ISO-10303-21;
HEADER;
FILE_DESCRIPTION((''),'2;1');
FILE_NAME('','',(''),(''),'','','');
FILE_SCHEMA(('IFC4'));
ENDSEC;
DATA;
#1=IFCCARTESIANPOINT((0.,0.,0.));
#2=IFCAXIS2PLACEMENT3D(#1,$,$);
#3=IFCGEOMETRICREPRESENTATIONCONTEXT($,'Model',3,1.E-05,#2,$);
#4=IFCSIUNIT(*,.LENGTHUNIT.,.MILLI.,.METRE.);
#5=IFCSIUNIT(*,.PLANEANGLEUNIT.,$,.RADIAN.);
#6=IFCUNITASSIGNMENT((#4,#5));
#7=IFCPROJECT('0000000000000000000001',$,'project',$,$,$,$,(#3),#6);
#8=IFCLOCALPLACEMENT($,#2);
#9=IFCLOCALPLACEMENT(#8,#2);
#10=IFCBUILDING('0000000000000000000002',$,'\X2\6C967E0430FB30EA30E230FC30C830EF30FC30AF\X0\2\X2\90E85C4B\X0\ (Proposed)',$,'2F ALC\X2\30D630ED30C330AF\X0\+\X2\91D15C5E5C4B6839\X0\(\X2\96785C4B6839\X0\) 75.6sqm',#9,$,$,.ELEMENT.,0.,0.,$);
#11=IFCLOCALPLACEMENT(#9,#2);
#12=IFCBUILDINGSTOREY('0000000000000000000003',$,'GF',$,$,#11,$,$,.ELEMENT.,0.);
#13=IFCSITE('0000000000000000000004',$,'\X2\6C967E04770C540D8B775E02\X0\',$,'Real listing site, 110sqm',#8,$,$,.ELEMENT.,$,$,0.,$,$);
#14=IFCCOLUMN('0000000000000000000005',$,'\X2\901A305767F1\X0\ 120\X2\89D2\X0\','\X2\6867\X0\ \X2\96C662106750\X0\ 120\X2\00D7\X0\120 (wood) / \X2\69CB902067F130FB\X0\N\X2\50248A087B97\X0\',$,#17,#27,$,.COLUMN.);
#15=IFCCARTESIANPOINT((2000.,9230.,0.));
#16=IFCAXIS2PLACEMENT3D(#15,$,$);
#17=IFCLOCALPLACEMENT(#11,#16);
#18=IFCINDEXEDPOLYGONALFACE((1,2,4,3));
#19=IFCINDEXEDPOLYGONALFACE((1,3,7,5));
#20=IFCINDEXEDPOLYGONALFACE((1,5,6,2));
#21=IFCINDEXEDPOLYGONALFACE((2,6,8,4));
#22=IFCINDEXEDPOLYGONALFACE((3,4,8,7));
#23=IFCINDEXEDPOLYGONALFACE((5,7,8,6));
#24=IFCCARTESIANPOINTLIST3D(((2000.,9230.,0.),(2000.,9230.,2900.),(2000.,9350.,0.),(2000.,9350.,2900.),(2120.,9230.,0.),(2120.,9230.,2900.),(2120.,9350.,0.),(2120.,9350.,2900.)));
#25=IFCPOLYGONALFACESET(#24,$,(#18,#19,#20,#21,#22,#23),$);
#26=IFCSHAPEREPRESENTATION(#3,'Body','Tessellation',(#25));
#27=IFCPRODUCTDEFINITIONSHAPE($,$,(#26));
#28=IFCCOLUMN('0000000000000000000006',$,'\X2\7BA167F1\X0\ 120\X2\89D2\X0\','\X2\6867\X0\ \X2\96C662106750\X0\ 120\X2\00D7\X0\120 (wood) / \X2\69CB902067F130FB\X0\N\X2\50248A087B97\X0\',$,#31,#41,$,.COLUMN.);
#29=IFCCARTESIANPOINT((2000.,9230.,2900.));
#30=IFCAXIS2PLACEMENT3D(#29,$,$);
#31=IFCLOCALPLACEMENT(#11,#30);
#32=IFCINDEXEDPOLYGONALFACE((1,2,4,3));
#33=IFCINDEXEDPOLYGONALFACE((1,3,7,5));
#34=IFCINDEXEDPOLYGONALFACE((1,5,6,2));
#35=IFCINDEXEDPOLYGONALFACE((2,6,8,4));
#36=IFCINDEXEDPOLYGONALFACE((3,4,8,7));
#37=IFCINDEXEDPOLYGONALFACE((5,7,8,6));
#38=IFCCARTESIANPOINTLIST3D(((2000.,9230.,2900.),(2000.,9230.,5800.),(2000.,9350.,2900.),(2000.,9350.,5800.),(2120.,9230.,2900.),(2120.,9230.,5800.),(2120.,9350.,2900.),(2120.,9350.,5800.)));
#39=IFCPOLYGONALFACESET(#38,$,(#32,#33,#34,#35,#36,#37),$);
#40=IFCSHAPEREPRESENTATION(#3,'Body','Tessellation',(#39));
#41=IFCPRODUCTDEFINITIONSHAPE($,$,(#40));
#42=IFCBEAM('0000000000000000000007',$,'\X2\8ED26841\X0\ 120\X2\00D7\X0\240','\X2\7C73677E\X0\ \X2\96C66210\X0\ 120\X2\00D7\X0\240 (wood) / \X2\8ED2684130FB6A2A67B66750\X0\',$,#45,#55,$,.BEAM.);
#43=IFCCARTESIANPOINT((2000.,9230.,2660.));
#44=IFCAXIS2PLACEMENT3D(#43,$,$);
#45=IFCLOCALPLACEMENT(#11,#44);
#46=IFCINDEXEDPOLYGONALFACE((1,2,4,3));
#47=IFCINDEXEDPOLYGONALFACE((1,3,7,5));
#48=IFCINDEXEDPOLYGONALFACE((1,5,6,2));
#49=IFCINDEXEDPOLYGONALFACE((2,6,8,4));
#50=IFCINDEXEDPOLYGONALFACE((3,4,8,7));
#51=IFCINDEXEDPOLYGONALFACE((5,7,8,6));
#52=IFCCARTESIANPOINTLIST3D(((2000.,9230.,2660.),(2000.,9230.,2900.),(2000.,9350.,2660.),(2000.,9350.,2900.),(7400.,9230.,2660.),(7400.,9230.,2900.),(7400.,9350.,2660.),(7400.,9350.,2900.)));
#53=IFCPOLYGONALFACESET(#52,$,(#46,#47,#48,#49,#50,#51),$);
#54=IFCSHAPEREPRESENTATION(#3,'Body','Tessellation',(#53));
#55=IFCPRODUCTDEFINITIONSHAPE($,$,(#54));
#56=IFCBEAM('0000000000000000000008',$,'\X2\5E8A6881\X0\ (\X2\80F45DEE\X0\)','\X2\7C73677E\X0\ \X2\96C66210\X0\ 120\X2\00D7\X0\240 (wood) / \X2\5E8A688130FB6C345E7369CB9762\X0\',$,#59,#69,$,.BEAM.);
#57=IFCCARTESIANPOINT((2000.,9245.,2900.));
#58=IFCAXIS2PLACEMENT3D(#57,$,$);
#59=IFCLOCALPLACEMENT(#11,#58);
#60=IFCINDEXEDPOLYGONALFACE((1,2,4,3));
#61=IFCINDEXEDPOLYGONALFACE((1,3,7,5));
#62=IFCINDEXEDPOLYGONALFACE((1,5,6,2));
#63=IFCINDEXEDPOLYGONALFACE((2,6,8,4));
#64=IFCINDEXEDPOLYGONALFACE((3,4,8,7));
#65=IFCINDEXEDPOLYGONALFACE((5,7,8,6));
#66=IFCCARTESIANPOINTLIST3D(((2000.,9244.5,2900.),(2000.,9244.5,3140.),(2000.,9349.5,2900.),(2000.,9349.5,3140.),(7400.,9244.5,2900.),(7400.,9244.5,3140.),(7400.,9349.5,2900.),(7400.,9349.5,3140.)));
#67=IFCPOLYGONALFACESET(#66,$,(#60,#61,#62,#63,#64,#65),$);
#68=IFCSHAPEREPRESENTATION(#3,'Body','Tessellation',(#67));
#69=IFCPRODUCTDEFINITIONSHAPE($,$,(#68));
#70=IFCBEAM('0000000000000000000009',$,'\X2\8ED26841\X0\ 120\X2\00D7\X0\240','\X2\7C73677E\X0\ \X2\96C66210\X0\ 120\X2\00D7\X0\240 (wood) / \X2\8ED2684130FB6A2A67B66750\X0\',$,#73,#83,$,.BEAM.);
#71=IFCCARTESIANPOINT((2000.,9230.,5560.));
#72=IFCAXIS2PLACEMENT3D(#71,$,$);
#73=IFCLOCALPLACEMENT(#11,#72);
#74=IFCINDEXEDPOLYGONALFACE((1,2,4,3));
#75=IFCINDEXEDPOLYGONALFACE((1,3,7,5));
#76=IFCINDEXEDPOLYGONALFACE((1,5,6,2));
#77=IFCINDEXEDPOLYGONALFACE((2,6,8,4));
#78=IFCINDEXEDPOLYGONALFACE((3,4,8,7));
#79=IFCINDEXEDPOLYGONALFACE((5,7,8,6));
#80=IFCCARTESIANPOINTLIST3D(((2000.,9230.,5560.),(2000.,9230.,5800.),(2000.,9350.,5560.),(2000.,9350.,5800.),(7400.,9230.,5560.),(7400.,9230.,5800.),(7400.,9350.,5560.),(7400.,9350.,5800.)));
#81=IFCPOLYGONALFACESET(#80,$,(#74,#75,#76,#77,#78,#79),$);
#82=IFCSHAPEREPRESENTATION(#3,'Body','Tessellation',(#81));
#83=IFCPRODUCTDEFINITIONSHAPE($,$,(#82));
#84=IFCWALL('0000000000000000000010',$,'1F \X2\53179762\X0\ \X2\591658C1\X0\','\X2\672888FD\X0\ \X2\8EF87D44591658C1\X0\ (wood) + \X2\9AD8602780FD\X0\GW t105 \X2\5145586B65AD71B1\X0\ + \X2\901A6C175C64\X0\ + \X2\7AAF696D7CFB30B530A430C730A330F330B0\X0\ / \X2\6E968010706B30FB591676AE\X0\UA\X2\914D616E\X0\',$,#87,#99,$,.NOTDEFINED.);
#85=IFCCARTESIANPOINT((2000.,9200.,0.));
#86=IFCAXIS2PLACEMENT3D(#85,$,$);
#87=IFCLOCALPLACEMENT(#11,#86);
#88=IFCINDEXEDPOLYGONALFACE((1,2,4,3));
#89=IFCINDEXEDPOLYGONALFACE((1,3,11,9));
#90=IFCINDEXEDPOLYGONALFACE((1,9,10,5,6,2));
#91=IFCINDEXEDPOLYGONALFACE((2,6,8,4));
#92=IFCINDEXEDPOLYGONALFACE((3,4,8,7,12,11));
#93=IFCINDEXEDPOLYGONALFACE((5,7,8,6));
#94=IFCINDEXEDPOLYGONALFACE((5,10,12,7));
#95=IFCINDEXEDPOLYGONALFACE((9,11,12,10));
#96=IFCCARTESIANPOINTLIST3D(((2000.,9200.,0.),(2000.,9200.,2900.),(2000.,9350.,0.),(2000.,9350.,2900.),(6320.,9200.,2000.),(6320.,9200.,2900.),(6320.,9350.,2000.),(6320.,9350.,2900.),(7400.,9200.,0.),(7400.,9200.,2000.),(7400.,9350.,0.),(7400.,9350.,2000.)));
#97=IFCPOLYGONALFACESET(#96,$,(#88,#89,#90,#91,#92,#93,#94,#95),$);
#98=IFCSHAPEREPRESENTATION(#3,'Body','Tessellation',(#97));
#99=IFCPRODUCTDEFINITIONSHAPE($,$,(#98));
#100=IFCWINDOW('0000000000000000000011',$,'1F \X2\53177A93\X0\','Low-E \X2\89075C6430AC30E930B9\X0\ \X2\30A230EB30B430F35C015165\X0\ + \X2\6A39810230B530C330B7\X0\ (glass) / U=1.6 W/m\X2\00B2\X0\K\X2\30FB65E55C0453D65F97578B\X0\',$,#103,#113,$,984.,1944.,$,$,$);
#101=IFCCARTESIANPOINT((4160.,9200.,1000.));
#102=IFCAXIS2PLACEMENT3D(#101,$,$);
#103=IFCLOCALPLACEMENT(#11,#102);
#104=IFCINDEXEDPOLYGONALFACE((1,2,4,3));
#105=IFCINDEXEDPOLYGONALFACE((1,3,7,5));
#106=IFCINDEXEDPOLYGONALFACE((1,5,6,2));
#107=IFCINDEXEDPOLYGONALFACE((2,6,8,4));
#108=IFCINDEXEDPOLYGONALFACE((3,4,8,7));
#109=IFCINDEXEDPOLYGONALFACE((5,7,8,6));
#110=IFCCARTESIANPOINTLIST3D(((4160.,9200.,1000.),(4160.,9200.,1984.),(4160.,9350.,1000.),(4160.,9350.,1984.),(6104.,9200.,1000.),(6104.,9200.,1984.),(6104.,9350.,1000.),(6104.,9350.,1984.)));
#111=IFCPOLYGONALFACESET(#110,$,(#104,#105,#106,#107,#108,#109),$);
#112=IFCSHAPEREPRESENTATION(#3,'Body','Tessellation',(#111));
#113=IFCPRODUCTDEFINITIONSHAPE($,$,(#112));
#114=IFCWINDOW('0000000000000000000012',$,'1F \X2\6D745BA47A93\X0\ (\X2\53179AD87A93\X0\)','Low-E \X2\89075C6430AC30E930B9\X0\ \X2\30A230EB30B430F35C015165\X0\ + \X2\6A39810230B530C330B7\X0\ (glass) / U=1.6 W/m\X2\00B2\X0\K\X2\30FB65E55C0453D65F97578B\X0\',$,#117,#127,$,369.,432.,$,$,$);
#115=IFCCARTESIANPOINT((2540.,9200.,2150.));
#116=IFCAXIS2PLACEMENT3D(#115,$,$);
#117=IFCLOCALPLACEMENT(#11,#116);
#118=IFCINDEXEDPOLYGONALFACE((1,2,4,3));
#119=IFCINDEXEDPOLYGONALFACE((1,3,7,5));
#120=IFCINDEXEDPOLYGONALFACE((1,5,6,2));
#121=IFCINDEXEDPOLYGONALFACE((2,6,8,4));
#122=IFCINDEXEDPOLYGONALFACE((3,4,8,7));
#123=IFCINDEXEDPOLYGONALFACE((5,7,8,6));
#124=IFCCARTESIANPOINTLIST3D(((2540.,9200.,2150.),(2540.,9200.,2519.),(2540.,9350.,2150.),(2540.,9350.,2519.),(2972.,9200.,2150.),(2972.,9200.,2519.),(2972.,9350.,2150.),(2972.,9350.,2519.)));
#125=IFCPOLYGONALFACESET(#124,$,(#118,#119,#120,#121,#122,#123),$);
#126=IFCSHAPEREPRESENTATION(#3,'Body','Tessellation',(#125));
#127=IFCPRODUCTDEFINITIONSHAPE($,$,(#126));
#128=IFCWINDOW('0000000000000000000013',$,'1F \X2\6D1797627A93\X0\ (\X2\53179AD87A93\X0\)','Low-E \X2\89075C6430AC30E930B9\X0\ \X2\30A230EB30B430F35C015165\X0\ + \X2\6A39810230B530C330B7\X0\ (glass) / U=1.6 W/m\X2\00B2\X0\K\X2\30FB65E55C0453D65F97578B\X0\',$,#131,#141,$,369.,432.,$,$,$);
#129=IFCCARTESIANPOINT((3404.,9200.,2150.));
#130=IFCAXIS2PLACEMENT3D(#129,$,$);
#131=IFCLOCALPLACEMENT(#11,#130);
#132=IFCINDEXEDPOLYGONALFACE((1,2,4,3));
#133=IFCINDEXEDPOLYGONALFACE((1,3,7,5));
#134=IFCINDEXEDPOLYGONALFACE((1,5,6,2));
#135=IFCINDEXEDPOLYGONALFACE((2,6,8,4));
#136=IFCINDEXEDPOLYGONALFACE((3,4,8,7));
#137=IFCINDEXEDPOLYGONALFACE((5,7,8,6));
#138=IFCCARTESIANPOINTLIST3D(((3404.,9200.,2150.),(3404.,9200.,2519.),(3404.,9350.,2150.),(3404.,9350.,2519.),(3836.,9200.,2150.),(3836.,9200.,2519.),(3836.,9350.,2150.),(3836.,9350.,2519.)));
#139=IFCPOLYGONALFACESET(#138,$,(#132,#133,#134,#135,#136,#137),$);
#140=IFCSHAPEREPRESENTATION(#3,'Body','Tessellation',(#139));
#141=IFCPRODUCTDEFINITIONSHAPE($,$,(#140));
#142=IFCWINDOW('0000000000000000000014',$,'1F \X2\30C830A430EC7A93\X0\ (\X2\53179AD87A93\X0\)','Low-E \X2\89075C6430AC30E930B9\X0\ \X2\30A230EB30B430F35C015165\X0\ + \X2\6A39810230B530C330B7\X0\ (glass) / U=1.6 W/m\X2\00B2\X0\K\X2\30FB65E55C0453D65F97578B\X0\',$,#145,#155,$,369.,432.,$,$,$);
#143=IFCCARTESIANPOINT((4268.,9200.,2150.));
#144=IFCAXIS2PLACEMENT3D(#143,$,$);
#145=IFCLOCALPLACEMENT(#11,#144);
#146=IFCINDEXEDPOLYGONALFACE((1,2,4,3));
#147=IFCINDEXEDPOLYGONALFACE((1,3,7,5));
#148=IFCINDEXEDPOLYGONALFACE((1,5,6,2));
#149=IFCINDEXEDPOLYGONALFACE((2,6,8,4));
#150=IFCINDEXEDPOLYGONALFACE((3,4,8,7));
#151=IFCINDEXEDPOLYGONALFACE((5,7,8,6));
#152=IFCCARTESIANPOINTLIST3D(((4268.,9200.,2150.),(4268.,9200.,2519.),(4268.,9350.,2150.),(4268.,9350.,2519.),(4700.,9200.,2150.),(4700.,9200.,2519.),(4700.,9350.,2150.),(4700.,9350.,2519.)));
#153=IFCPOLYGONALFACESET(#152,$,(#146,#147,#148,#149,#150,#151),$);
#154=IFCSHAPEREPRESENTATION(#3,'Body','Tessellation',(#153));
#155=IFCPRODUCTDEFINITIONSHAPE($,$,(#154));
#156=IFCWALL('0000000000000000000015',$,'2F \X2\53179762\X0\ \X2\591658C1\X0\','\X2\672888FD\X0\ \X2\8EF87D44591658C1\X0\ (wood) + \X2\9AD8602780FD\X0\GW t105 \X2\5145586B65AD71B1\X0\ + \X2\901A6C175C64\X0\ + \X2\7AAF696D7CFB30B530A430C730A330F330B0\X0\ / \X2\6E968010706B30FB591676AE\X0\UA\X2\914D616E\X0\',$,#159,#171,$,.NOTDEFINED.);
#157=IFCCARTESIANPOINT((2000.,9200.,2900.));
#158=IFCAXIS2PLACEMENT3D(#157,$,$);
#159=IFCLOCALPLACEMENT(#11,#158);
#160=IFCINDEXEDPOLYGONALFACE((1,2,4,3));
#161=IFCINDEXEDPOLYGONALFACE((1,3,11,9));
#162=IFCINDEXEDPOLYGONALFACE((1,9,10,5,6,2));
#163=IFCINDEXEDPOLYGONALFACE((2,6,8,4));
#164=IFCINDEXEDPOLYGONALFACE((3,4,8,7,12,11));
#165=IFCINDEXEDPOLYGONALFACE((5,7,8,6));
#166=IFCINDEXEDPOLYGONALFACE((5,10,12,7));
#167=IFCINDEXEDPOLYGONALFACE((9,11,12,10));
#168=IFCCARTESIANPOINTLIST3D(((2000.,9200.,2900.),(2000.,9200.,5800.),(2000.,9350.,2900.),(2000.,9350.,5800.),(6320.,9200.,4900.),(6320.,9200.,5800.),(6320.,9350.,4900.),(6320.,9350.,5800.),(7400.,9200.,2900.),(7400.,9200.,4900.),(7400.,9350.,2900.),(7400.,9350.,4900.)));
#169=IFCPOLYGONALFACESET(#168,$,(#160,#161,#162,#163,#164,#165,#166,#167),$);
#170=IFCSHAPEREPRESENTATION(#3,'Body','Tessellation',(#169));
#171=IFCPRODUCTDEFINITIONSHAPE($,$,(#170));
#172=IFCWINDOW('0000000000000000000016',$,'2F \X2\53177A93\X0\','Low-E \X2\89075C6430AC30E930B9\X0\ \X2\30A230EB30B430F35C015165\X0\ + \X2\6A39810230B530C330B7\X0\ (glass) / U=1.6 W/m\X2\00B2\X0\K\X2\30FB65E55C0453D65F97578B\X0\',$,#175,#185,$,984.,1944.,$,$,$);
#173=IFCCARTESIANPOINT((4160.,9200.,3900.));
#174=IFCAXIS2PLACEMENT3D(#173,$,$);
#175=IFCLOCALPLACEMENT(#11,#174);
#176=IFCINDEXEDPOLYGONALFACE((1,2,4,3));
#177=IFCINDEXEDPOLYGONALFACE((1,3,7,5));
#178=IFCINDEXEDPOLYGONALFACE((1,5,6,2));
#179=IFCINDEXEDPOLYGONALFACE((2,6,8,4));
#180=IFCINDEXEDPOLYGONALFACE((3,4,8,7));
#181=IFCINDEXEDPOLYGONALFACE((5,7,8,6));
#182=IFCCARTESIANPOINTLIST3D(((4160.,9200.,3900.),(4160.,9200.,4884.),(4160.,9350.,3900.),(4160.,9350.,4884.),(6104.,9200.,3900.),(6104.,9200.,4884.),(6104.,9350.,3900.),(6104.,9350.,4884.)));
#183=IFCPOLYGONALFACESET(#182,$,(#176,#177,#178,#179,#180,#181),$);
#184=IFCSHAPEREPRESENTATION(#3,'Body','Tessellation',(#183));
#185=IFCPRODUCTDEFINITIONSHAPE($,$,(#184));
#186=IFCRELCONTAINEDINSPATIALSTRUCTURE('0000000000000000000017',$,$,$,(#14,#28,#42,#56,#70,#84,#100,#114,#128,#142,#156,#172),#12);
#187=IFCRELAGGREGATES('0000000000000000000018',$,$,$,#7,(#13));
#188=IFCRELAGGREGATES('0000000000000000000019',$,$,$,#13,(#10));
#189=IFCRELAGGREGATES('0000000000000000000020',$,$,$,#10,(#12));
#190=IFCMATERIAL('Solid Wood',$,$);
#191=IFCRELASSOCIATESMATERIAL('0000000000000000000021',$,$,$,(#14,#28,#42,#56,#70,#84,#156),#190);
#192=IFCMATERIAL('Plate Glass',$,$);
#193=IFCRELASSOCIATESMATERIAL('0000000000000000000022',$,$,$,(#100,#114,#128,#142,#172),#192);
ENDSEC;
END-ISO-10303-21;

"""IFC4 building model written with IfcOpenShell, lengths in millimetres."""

from ifc_helpers import new_model, si_unit, frame, frame_2d, origin, place, context, project, spatial, rectangle, extrude, material, element, fill, save


model = new_model("IFC4")

# Units and contexts
model_context = context("Model", 3, precision=1e-05, world=origin())
ifc_project = project(units=[si_unit("LENGTHUNIT", "METRE", prefix="MILLI"), si_unit("PLANEANGLEUNIT", "RADIAN")], contexts=[model_context])

# Site, building, storey
site_placement = place(None, origin())
site = spatial("IfcSite", under=ifc_project, at=site_placement, Name="沖縄県名護市", ObjectType="Real listing site, 110sqm", CompositionType="ELEMENT", RefElevation=0.0)
building_placement = place(site_placement, origin())
building = spatial("IfcBuilding", under=site, at=building_placement, Name="沖縄・リモートワーク2部屋 (Proposed)", ObjectType="2F ALCブロック+金属屋根(陸屋根) 75.6sqm", CompositionType="ELEMENT", ElevationOfRefHeight=0.0, ElevationOfTerrain=0.0)
storey_placement = place(building_placement, origin())
storey = spatial("IfcBuildingStorey", under=building, at=storey_placement, Name="GF", CompositionType="ELEMENT", Elevation=0.0)

# Columns
ifc_material_1 = material(Name="Solid Wood")
column_1_placement = place(storey_placement, frame((2000.0, 9230.0, 0.0)))
element("IfcColumn", 1, at=column_1_placement, inside=storey, material=ifc_material_1, Name="通し柱 120角", Description="桧 集成材 120×120 (wood) / 構造柱・N値計算", PredefinedType="COLUMN", context=model_context, shape_type="SweptSolid", body=[
    extrude(rectangle(XDim=120.0, YDim=120.0, at=frame_2d((60.0, 60.0))), frame((2000.0, 9230.0, 0.0)), (0.0, 0.0, 1.0), 2900.0),
])
column_2_placement = place(storey_placement, frame((2000.0, 9230.0, 2900.0)))
element("IfcColumn", 2, at=column_2_placement, inside=storey, material=ifc_material_1, Name="管柱 120角", Description="桧 集成材 120×120 (wood) / 構造柱・N値計算", PredefinedType="COLUMN", context=model_context, shape_type="SweptSolid", body=[
    extrude(rectangle(XDim=120.0, YDim=120.0, at=frame_2d((60.0, 60.0))), frame((2000.0, 9230.0, 2900.0)), (0.0, 0.0, 1.0), 2900.0),
])

# Beams
beam_1_placement = place(storey_placement, frame((2000.0, 9230.0, 2660.0)))
element("IfcBeam", 3, at=beam_1_placement, inside=storey, material=ifc_material_1, Name="軒桁 120×240", Description="米松 集成 120×240 (wood) / 軒桁・横架材", PredefinedType="BEAM", context=model_context, shape_type="SweptSolid", body=[
    extrude(rectangle(XDim=5400.0, YDim=120.0, at=frame_2d((2700.0, 60.0))), frame((2000.0, 9230.0, 2660.0)), (0.0, 0.0, 1.0), 240.0),
])
beam_2_placement = place(storey_placement, frame((2000.0, 9245.0, 2900.0)))
element("IfcBeam", 4, at=beam_2_placement, inside=storey, material=ifc_material_1, Name="床梁 (胴差)", Description="米松 集成 120×240 (wood) / 床梁・水平構面", PredefinedType="BEAM", context=model_context, shape_type="SweptSolid", body=[
    extrude(rectangle(XDim=5400.0, YDim=105.0, at=frame_2d((2700.0, 52.0))), frame((2000.0, 9245.0, 2900.0)), (0.0, 0.0, 1.0), 240.0),
])
beam_3_placement = place(storey_placement, frame((2000.0, 9230.0, 5560.0)))
element("IfcBeam", 5, at=beam_3_placement, inside=storey, material=ifc_material_1, Name="軒桁 120×240", Description="米松 集成 120×240 (wood) / 軒桁・横架材", PredefinedType="BEAM", context=model_context, shape_type="SweptSolid", body=[
    extrude(rectangle(XDim=5400.0, YDim=120.0, at=frame_2d((2700.0, 60.0))), frame((2000.0, 9230.0, 5560.0)), (0.0, 0.0, 1.0), 240.0),
])

# Wall, openings, windows
wall_1_placement = place(storey_placement, frame((2000.0, 9200.0, 0.0)))
wall_1 = element("IfcWall", 6, at=wall_1_placement, inside=storey, material=ifc_material_1, Name="1F 北面 外壁", Description="木製 軸組外壁 (wood) + 高性能GW t105 充填断熱 + 通気層 + 窯業系サイディング / 準耐火・外皮UA配慮", PredefinedType="NOTDEFINED", context=model_context, shape_type="SweptSolid", body=[
    extrude(rectangle(XDim=5400.0, YDim=150.0, at=frame_2d((2700.0, 75.0))), frame((2000.0, 9200.0, 0.0)), (0.0, 0.0, 1.0), 2900.0),
])
opening_1_placement = place(storey_placement, frame((4160.0, 9200.0, 1000.0)))
opening_1 = element("IfcOpeningElement", 7, at=opening_1_placement, cuts=wall_1, PredefinedType="NOTDEFINED", context=model_context, shape_type="SweptSolid", body=[
    extrude(rectangle(XDim=1944.0, YDim=150.0, at=frame_2d((972.0, 75.0))), frame((4160.0, 9200.0, 1000.0)), (0.0, 0.0, 1.0), 984.0),
])
opening_2_placement = place(storey_placement, frame((2540.0, 9200.0, 2150.0)))
opening_2 = element("IfcOpeningElement", 8, at=opening_2_placement, cuts=wall_1, PredefinedType="NOTDEFINED", context=model_context, shape_type="SweptSolid", body=[
    extrude(rectangle(XDim=432.0, YDim=150.0, at=frame_2d((216.0, 75.0))), frame((2540.0, 9200.0, 2150.0)), (0.0, 0.0, 1.0), 369.0),
])
opening_3_placement = place(storey_placement, frame((3404.0, 9200.0, 2150.0)))
opening_3 = element("IfcOpeningElement", 9, at=opening_3_placement, cuts=wall_1, PredefinedType="NOTDEFINED", context=model_context, shape_type="SweptSolid", body=[
    extrude(rectangle(XDim=432.0, YDim=150.0, at=frame_2d((216.0, 75.0))), frame((3404.0, 9200.0, 2150.0)), (0.0, 0.0, 1.0), 369.0),
])
opening_4_placement = place(storey_placement, frame((4268.0, 9200.0, 2150.0)))
opening_4 = element("IfcOpeningElement", 10, at=opening_4_placement, cuts=wall_1, PredefinedType="NOTDEFINED", context=model_context, shape_type="SweptSolid", body=[
    extrude(rectangle(XDim=432.0, YDim=150.0, at=frame_2d((216.0, 75.0))), frame((4268.0, 9200.0, 2150.0)), (0.0, 0.0, 1.0), 369.0),
])
ifc_material_2 = material(Name="Plate Glass")
window_1_placement = place(storey_placement, frame((4160.0, 9200.0, 1000.0)))
window_1 = element("IfcWindow", 11, at=window_1_placement, inside=storey, material=ifc_material_2, Name="1F 北窓", Description="Low-E 複層ガラス アルゴン封入 + 樹脂サッシ (glass) / U=1.6 W/m²K・日射取得型", OverallHeight=984.0, OverallWidth=1944.0, context=model_context, shape_type="SweptSolid", body=[
    extrude(rectangle(XDim=1944.0, YDim=150.0, at=frame_2d((972.0, 75.0))), frame((4160.0, 9200.0, 1000.0)), (0.0, 0.0, 1.0), 984.0),
])
fill(opening_1, window_1)
window_2_placement = place(storey_placement, frame((2540.0, 9200.0, 2150.0)))
window_2 = element("IfcWindow", 12, at=window_2_placement, inside=storey, material=ifc_material_2, Name="1F 浴室窓 (北高窓)", Description="Low-E 複層ガラス アルゴン封入 + 樹脂サッシ (glass) / U=1.6 W/m²K・日射取得型", OverallHeight=369.0, OverallWidth=432.0, context=model_context, shape_type="SweptSolid", body=[
    extrude(rectangle(XDim=432.0, YDim=150.0, at=frame_2d((216.0, 75.0))), frame((2540.0, 9200.0, 2150.0)), (0.0, 0.0, 1.0), 369.0),
])
fill(opening_2, window_2)
window_3_placement = place(storey_placement, frame((3404.0, 9200.0, 2150.0)))
window_3 = element("IfcWindow", 13, at=window_3_placement, inside=storey, material=ifc_material_2, Name="1F 洗面窓 (北高窓)", Description="Low-E 複層ガラス アルゴン封入 + 樹脂サッシ (glass) / U=1.6 W/m²K・日射取得型", OverallHeight=369.0, OverallWidth=432.0, context=model_context, shape_type="SweptSolid", body=[
    extrude(rectangle(XDim=432.0, YDim=150.0, at=frame_2d((216.0, 75.0))), frame((3404.0, 9200.0, 2150.0)), (0.0, 0.0, 1.0), 369.0),
])
fill(opening_3, window_3)
window_4_placement = place(storey_placement, frame((4268.0, 9200.0, 2150.0)))
window_4 = element("IfcWindow", 14, at=window_4_placement, inside=storey, material=ifc_material_2, Name="1F トイレ窓 (北高窓)", Description="Low-E 複層ガラス アルゴン封入 + 樹脂サッシ (glass) / U=1.6 W/m²K・日射取得型", OverallHeight=369.0, OverallWidth=432.0, context=model_context, shape_type="SweptSolid", body=[
    extrude(rectangle(XDim=432.0, YDim=150.0, at=frame_2d((216.0, 75.0))), frame((4268.0, 9200.0, 2150.0)), (0.0, 0.0, 1.0), 369.0),
])
fill(opening_4, window_4)

# Wall, opening, window
wall_2_placement = place(storey_placement, frame((2000.0, 9200.0, 2900.0)))
wall_2 = element("IfcWall", 15, at=wall_2_placement, inside=storey, material=ifc_material_1, Name="2F 北面 外壁", Description="木製 軸組外壁 (wood) + 高性能GW t105 充填断熱 + 通気層 + 窯業系サイディング / 準耐火・外皮UA配慮", PredefinedType="NOTDEFINED", context=model_context, shape_type="SweptSolid", body=[
    extrude(rectangle(XDim=5400.0, YDim=150.0, at=frame_2d((2700.0, 75.0))), frame((2000.0, 9200.0, 2900.0)), (0.0, 0.0, 1.0), 2900.0),
])
opening_5_placement = place(storey_placement, frame((4160.0, 9200.0, 3900.0)))
opening_5 = element("IfcOpeningElement", 16, at=opening_5_placement, cuts=wall_2, PredefinedType="NOTDEFINED", context=model_context, shape_type="SweptSolid", body=[
    extrude(rectangle(XDim=1944.0, YDim=150.0, at=frame_2d((972.0, 75.0))), frame((4160.0, 9200.0, 3900.0)), (0.0, 0.0, 1.0), 984.0),
])
window_5_placement = place(storey_placement, frame((4160.0, 9200.0, 3900.0)))
window_5 = element("IfcWindow", 17, at=window_5_placement, inside=storey, material=ifc_material_2, Name="2F 北窓", Description="Low-E 複層ガラス アルゴン封入 + 樹脂サッシ (glass) / U=1.6 W/m²K・日射取得型", OverallHeight=984.0, OverallWidth=1944.0, context=model_context, shape_type="SweptSolid", body=[
    extrude(rectangle(XDim=1944.0, YDim=150.0, at=frame_2d((972.0, 75.0))), frame((4160.0, 9200.0, 3900.0)), (0.0, 0.0, 1.0), 984.0),
])
fill(opening_5, window_5)

save(model, "model.ifc")
